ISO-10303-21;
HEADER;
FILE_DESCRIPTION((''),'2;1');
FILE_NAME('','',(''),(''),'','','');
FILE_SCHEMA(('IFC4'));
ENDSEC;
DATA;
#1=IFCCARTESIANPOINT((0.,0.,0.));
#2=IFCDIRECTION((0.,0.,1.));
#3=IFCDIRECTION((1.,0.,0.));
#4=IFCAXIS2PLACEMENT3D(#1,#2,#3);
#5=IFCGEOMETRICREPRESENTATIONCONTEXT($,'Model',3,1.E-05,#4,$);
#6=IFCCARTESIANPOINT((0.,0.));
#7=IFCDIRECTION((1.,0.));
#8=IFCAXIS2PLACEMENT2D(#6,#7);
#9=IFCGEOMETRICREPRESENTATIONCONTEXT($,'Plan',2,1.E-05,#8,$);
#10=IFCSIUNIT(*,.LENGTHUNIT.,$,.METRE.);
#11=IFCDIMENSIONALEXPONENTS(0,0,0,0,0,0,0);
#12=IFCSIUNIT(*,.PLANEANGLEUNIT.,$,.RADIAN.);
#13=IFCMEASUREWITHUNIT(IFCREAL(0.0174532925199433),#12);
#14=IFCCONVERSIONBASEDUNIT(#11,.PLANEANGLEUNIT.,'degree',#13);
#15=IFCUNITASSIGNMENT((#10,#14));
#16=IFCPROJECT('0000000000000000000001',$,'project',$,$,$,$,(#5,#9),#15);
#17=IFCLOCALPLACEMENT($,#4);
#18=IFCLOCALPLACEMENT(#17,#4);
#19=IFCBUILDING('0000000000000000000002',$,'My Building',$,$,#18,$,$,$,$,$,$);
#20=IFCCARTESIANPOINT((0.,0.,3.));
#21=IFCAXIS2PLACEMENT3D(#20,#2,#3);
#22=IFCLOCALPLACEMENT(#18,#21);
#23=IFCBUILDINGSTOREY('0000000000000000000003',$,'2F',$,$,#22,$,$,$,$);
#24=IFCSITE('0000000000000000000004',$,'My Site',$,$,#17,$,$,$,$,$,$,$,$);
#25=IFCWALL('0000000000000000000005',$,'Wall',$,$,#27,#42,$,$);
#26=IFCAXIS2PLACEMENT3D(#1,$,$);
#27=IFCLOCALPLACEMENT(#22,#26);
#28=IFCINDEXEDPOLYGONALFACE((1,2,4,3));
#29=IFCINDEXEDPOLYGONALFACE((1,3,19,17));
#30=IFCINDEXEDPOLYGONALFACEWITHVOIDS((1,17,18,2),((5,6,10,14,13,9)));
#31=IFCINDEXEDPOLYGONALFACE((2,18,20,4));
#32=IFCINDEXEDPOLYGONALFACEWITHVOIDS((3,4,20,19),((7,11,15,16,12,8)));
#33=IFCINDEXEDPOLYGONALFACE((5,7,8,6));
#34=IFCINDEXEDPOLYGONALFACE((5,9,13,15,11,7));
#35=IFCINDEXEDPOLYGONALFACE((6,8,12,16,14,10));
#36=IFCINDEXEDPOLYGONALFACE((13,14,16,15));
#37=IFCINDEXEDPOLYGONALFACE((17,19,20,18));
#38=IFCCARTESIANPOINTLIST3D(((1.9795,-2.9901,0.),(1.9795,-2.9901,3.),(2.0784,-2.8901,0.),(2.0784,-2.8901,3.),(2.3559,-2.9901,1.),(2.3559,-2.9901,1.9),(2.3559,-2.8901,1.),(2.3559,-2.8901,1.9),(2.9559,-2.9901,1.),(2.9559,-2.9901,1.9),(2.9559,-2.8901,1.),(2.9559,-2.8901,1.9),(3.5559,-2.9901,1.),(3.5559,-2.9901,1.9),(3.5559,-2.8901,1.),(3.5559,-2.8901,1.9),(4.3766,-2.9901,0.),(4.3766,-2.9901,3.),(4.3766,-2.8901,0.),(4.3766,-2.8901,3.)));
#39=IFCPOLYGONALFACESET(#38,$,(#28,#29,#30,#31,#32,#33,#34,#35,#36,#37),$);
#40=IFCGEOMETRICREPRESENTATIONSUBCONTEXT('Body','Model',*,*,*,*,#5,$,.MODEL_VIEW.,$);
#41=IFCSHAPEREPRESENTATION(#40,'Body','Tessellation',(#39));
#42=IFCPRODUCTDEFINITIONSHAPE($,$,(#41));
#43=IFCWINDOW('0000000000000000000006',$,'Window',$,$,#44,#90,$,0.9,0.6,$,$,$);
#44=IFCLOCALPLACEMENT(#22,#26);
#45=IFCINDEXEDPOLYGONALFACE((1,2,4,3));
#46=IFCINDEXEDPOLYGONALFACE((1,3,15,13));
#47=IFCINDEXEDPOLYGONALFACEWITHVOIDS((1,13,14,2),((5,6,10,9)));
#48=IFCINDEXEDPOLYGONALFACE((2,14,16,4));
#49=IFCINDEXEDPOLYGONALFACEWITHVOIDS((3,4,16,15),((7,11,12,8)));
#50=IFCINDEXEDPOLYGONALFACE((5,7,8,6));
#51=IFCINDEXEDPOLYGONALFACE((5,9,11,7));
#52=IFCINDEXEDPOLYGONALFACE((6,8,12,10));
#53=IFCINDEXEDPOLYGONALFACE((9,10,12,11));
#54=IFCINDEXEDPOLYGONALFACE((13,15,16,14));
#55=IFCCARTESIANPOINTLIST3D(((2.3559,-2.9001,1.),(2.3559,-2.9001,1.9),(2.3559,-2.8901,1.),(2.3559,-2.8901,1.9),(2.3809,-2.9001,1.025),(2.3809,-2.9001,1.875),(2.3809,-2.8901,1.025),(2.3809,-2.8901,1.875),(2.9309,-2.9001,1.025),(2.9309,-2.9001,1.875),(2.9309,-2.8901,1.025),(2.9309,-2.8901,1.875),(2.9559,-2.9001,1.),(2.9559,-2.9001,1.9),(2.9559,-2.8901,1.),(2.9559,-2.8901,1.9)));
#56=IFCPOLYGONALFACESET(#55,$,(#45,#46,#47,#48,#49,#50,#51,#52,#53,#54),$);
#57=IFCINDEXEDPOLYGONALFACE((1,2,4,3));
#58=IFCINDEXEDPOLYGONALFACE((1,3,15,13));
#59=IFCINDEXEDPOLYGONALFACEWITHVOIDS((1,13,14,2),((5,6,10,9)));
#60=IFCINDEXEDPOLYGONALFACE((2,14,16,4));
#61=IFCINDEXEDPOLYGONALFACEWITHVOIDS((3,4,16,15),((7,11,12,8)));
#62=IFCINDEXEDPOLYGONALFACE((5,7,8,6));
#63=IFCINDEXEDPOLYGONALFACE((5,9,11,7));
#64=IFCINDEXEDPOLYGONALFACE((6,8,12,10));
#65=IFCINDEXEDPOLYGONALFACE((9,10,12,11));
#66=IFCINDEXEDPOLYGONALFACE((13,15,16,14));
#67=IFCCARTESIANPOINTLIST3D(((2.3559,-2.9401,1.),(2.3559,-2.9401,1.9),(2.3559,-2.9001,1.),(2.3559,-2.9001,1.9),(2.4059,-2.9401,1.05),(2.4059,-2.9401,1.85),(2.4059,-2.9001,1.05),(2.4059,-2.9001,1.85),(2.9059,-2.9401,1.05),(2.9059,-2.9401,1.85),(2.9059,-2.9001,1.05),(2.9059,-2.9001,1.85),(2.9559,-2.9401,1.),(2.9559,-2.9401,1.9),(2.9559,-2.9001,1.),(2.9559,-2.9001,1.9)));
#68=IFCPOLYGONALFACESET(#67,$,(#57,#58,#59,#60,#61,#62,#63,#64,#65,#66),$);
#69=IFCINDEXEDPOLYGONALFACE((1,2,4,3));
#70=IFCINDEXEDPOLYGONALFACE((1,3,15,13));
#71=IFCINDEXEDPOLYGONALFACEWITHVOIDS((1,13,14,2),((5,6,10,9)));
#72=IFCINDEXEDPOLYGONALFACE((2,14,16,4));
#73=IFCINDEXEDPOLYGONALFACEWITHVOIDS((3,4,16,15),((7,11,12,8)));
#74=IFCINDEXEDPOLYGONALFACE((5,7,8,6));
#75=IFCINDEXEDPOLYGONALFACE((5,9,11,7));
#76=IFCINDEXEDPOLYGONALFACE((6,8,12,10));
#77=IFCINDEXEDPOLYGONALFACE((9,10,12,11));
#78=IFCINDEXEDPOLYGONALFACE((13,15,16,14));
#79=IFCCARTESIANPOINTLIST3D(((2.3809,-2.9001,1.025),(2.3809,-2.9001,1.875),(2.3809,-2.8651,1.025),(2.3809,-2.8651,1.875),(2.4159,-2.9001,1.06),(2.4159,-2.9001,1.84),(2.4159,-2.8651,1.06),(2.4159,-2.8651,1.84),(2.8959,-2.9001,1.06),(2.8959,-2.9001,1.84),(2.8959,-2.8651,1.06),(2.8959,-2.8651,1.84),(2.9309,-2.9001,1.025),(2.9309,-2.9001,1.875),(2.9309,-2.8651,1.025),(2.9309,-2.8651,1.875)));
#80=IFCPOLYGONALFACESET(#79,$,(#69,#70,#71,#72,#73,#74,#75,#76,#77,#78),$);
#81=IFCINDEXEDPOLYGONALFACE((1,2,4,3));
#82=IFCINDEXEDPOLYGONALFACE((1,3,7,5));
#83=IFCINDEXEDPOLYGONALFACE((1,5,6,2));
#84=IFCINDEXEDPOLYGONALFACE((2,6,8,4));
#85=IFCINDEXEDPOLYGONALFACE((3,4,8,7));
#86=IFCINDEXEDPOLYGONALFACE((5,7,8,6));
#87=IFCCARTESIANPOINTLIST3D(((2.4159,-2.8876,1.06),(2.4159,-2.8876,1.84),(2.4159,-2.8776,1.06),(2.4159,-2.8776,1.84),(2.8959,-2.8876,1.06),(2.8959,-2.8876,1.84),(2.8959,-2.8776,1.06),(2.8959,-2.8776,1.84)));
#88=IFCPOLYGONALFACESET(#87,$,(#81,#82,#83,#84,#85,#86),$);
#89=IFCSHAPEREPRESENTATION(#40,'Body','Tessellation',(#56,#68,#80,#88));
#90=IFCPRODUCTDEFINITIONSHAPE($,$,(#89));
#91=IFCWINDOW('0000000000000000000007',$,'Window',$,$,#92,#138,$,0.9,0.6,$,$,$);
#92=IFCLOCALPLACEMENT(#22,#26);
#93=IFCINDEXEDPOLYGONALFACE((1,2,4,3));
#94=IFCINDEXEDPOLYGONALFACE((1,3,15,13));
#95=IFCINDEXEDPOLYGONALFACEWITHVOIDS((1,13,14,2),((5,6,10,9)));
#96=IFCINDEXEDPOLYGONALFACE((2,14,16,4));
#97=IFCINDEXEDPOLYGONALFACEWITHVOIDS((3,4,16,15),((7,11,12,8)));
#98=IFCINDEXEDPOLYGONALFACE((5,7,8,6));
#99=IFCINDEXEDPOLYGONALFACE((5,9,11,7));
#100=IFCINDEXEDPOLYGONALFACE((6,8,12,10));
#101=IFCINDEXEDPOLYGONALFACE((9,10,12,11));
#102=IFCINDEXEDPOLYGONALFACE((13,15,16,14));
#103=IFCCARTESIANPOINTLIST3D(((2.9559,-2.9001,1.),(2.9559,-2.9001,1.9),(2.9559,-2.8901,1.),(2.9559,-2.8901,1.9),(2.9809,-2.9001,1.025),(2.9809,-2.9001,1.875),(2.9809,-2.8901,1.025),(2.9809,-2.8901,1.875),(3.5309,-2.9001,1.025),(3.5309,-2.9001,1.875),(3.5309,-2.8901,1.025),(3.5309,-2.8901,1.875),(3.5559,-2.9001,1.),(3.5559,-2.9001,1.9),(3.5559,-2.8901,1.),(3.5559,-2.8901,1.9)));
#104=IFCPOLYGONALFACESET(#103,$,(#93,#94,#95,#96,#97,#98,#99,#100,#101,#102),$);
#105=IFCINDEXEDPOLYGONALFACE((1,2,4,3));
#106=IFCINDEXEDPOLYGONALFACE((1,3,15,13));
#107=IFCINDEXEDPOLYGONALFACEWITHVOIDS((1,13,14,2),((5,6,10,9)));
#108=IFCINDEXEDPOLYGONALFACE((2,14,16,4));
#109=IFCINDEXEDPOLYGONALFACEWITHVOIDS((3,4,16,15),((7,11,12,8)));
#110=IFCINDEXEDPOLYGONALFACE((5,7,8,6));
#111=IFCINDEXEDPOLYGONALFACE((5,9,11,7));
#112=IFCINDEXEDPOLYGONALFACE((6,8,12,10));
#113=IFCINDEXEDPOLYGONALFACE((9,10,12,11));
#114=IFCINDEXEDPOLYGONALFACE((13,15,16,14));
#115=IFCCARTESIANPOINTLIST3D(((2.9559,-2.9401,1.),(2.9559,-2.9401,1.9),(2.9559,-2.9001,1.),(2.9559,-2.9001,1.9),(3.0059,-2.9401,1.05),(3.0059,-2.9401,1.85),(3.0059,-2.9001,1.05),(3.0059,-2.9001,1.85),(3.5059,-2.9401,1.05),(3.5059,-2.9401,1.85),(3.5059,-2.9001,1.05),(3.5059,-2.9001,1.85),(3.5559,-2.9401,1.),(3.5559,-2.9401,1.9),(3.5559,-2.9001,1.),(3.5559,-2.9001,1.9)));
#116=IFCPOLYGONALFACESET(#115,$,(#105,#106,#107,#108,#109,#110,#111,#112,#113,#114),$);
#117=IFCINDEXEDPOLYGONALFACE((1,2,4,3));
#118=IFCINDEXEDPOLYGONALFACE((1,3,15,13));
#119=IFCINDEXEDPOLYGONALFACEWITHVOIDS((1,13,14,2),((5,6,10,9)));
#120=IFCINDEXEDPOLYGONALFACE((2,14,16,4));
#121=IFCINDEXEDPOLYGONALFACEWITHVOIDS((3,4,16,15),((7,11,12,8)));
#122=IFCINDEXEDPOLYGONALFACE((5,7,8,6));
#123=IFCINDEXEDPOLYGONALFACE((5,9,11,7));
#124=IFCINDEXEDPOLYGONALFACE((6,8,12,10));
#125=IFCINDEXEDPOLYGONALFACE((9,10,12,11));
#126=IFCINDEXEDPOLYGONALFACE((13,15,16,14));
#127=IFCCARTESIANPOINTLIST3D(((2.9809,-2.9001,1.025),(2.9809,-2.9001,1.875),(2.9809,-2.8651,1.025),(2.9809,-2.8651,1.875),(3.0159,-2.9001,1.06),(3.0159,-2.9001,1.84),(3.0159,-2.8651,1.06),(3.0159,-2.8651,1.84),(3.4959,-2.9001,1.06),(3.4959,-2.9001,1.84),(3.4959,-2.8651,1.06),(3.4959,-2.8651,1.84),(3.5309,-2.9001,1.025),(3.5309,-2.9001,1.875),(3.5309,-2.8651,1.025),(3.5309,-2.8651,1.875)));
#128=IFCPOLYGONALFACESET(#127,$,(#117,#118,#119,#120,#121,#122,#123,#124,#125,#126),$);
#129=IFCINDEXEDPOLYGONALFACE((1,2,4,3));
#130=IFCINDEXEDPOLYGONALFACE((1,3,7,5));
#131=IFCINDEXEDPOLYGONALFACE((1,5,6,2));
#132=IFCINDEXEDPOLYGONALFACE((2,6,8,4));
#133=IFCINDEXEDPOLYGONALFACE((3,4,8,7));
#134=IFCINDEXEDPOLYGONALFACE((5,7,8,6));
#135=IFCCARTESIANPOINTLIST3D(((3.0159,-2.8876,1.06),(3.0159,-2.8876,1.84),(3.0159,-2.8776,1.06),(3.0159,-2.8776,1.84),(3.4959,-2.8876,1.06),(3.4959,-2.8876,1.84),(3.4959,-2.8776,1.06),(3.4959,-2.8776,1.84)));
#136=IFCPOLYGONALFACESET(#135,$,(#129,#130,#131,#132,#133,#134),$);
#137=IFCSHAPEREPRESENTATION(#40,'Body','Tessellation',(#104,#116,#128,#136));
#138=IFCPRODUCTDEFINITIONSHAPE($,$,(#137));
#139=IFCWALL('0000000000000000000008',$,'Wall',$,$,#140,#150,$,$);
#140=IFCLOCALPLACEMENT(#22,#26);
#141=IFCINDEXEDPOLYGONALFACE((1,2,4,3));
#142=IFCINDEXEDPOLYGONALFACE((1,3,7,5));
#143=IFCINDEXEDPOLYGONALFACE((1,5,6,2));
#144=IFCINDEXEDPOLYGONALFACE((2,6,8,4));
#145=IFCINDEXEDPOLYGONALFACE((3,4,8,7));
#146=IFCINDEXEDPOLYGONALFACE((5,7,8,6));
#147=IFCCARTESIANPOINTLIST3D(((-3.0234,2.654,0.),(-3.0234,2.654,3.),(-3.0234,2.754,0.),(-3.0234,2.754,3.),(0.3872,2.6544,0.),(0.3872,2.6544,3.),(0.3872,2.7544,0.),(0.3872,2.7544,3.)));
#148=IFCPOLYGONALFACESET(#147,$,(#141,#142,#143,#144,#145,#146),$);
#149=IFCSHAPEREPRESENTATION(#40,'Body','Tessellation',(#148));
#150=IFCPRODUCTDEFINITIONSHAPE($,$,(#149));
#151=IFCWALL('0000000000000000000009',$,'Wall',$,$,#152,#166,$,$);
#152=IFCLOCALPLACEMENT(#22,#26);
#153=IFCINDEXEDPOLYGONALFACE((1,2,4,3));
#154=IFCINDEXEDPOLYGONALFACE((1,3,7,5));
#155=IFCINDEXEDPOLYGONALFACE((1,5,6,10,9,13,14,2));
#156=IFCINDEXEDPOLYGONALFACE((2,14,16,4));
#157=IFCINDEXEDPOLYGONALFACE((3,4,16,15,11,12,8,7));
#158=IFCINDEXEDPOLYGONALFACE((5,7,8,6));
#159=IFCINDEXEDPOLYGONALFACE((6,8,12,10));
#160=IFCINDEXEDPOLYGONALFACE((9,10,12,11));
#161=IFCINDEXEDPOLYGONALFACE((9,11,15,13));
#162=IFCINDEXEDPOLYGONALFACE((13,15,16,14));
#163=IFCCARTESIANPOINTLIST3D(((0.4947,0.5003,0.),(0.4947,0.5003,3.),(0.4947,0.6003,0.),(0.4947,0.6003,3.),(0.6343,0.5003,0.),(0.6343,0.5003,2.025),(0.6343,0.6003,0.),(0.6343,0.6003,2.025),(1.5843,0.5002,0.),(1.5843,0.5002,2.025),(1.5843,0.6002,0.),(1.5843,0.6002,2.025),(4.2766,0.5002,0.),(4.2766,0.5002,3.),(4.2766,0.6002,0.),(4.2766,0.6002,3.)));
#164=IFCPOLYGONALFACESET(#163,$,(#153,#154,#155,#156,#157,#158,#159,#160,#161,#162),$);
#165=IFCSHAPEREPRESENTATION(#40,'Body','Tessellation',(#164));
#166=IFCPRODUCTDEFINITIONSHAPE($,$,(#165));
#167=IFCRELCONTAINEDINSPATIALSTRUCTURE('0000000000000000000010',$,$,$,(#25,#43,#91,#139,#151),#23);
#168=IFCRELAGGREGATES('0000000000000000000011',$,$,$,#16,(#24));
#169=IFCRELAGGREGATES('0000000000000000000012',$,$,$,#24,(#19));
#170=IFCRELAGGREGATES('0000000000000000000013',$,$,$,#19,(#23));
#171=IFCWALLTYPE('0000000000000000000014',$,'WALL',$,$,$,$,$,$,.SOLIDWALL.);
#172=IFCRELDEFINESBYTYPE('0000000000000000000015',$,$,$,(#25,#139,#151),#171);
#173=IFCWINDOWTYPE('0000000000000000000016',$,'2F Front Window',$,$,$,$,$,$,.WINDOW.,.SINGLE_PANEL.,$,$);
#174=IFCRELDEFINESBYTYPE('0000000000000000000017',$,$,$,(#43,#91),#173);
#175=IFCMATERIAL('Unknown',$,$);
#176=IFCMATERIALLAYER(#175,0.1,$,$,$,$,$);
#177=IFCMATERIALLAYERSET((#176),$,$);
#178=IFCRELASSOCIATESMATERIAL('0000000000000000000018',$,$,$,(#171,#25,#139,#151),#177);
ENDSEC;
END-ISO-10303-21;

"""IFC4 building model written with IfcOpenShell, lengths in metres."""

from ifc_helpers import new_model, entity, si_unit, converted_unit, frame, origin_with_axes, origin_2d_with_axis, place, context, subcontext, project, spatial, line, indexed_curve, outline, extrude, shape, source, transform, mapped, material, layer, layer_set, layer_usage, type_object, type_shapes, element, fill, save


model = new_model("IFC4")

# Units and contexts
model_context = context("Model", 3, precision=1e-05, world=origin_with_axes())
plan_context = context("Plan", 2, precision=1e-05, world=origin_2d_with_axis())
body_context_1 = subcontext(model_context, "Body", "Model", "MODEL_VIEW")
body_context_2 = subcontext(plan_context, "Body", "Plan", "PLAN_VIEW")
ifc_project = project(units=[si_unit("LENGTHUNIT", "METRE"), converted_unit("PLANEANGLEUNIT", "degree", entity("IfcReal", 0.0174532925199433), si_unit("PLANEANGLEUNIT", "RADIAN"), dimensions=[0, 0, 0, 0, 0, 0, 0])], contexts=[model_context, plan_context])

# Site, building, storey
site_placement = place(None, origin_with_axes())
site = spatial("IfcSite", under=ifc_project, at=site_placement, Name="My Site")
building_placement = place(site_placement, origin_with_axes())
building = spatial("IfcBuilding", under=site, at=building_placement, Name="My Building")
storey_placement = place(building_placement, frame((0.0, 0.0, 3.0), z_axis=(0.0, 0.0, 1.0), x_axis=(1.0, 0.0, 0.0)))
storey = spatial("IfcBuildingStorey", under=building, at=storey_placement, Name="2F")

# Shared definitions
ifc_material = material(Name="Unknown")

# Shared definitions
ifc_layer = layer(ifc_material, 0.1)
ifc_layer_set = layer_set([ifc_layer])
wall_type = type_object("IfcWallType", Name="WALL", PredefinedType="SOLIDWALL", material=ifc_layer_set)

# Wall, openings, windows
ifc_layer_usage_1 = layer_usage(ifc_layer_set, "AXIS2", "POSITIVE", 0.0)
wall_1_placement = place(storey_placement, frame((1.9795, -2.9901, 0.0), z_axis=(0.0, 0.0, 1.0), x_axis=(1.0, 0.0, 0.0)))
wall_1 = element("IfcWall", 1, at=wall_1_placement, inside=storey, type_object=wall_type, material=ifc_layer_usage_1, Name="Wall", context=body_context_1, shape_type="SweptSolid", body=[
    extrude(outline(indexed_curve([(0.0, 0.0), (0.0989, 0.1), (2.3971, 0.1), (2.3971, 0.0)], segments=[line(1, 2, 3, 4, 1)])), origin_with_axes(), (0.0, 0.0, 1.0), 3.0),
])
shared_shape_1 = source(origin_with_axes(), body_context_1, "Body", "SweptSolid", [
    extrude(outline(indexed_curve([(0.0, 0.0), (0.6, 0.0), (0.6, 0.9), (0.0, 0.9)], segments=[line(1, 2, 3, 4, 1)])), frame((0.0, -0.6, 0.0), z_axis=(0.0, -1.0, 0.0), x_axis=(1.0, 0.0, 0.0)), (0.0, 0.0, -1.0), 1.2),
])
opening_1_placement = place(wall_1_placement, frame((0.3764, 0.0, 1.0), z_axis=(0.0, 0.0, 1.0), x_axis=(1.0, 0.0, 0.0)))
opening_1 = element("IfcOpeningElement", 2, at=opening_1_placement, cuts=wall_1, PredefinedType="OPENING", context=body_context_1, shape_type="MappedRepresentation", body=[
    mapped(shared_shape_1, transform((0.0, 0.0, 0.0), x_axis=(1.0, 0.0, 0.0), y_axis=(0.0, 1.0, 0.0), z_axis=(0.0, 0.0, 1.0), scale=1.0)),
])
opening_2_placement = place(wall_1_placement, frame((0.9764, 0.0, 1.0), z_axis=(0.0, 0.0, 1.0), x_axis=(1.0, 0.0, 0.0)))
opening_2 = element("IfcOpeningElement", 3, at=opening_2_placement, cuts=wall_1, PredefinedType="OPENING", context=body_context_1, shape_type="MappedRepresentation", body=[
    mapped(shared_shape_1, transform((0.0, 0.0, 0.0), x_axis=(1.0, 0.0, 0.0), y_axis=(0.0, 1.0, 0.0), z_axis=(0.0, 0.0, 1.0), scale=1.0)),
])
window_type = type_object("IfcWindowType", Name="2F Front Window", PartitioningType="SINGLE_PANEL", PredefinedType="WINDOW")
shared_shape_2 = source(origin_with_axes(), body_context_1, "Body", "SweptSolid", [
    extrude(outline(indexed_curve([(0.0, 0.0), (0.6, 0.0), (0.6, 0.9), (0.0, 0.9)], segments=[line(1, 2, 3, 4, 1)]), holes=[indexed_curve([(0.025, 0.025), (0.575, 0.025), (0.575, 0.875), (0.025, 0.875)], segments=[line(1, 2, 3, 4, 1)])]), frame((0.0, 0.09, 0.0), z_axis=(0.0, -1.0, 0.0), x_axis=(1.0, 0.0, 0.0)), (0.0, 0.0, -1.0), 0.01),
    extrude(outline(indexed_curve([(0.0, 0.0), (0.6, 0.0), (0.6, 0.9), (0.0, 0.9)], segments=[line(1, 2, 3, 4, 1)]), holes=[indexed_curve([(0.05, 0.05), (0.55, 0.05), (0.55, 0.85), (0.05, 0.85)], segments=[line(1, 2, 3, 4, 1)])]), frame((0.0, 0.05, 0.0), z_axis=(0.0, -1.0, 0.0), x_axis=(1.0, 0.0, 0.0)), (0.0, 0.0, -1.0), 0.04),
    extrude(outline(indexed_curve([(0.0, 0.0), (0.55, 0.0), (0.55, 0.85), (0.0, 0.85)], segments=[line(1, 2, 3, 4, 1)]), holes=[indexed_curve([(0.035, 0.035), (0.515, 0.035), (0.515, 0.815), (0.035, 0.815)], segments=[line(1, 2, 3, 4, 1)])]), frame((0.025, 0.09, 0.025), z_axis=(0.0, -1.0, 0.0), x_axis=(1.0, 0.0, 0.0)), (0.0, 0.0, -1.0), 0.035),
    extrude(outline(indexed_curve([(0.035, 0.035), (0.515, 0.035), (0.515, 0.815), (0.035, 0.815)], segments=[line(1, 2, 3, 4, 1)])), frame((0.025, 0.1025, 0.025), z_axis=(0.0, -1.0, 0.0), x_axis=(1.0, 0.0, 0.0)), (0.0, 0.0, -1.0), 0.01),
])
shared_shape_3 = source(origin_with_axes(), body_context_2, "Body", "Curve2D", [
    entity("IfcIndexedPolyCurve", entity("IfcCartesianPointList2D", [[0.05, 0.05], [0.55, 0.05]])),
    entity("IfcIndexedPolyCurve", entity("IfcCartesianPointList2D", [[0.0, 0.1], [0.025, 0.1], [0.025, 0.09], [0.05, 0.09], [0.05, 0.05], [0.0, 0.05]]), [entity("IfcLineIndex", [1, 2, 3, 4, 5, 6, 1])]),
    entity("IfcIndexedPolyCurve", entity("IfcCartesianPointList2D", [[0.6, 0.1], [0.575, 0.1], [0.575, 0.09], [0.55, 0.09], [0.55, 0.05], [0.6, 0.05]]), [entity("IfcLineIndex", [1, 2, 3, 4, 5, 6, 1])]),
    entity("IfcIndexedPolyCurve", entity("IfcCartesianPointList2D", [[0.025, 0.09], [0.06, 0.09], [0.06, 0.125], [0.025, 0.125]]), [entity("IfcLineIndex", [1, 2, 3, 4, 1])]),
    entity("IfcIndexedPolyCurve", entity("IfcCartesianPointList2D", [[0.575, 0.09], [0.54, 0.09], [0.54, 0.125], [0.575, 0.125]]), [entity("IfcLineIndex", [1, 2, 3, 4, 1])]),
    entity("IfcIndexedPolyCurve", entity("IfcCartesianPointList2D", [[0.06, 0.09], [0.54, 0.09]])),
    entity("IfcIndexedPolyCurve", entity("IfcCartesianPointList2D", [[0.06, 0.125], [0.54, 0.125]])),
    entity("IfcIndexedPolyCurve", entity("IfcCartesianPointList2D", [[0.06, 0.1075], [0.54, 0.1075]])),
])
type_shapes(window_type, [shared_shape_2, shared_shape_3])
window_1_placement = place(opening_1_placement, frame((0.0, 0.0, 0.0), z_axis=(0.0, 0.0, 1.0), x_axis=(1.0, 0.0, 0.0)))
window_1 = element("IfcWindow", 4, at=window_1_placement, inside=storey, type_object=window_type, Name="Window", OverallHeight=0.9, OverallWidth=0.6, shapes=[
    shape(body_context_1, "Body", "MappedRepresentation", [mapped(shared_shape_2, transform((0.0, 0.0, 0.0), x_axis=(1.0, 0.0, 0.0), y_axis=(0.0, 1.0, 0.0), z_axis=(0.0, 0.0, 1.0), scale=1.0))]),
    shape(body_context_2, "Body", "MappedRepresentation", [mapped(shared_shape_3, transform((0.0, 0.0, 0.0), x_axis=(1.0, 0.0, 0.0), y_axis=(0.0, 1.0, 0.0), z_axis=(0.0, 0.0, 1.0), scale=1.0))]),
])
fill(opening_1, window_1)
window_2_placement = place(opening_2_placement, frame((0.0, 0.0, 0.0), z_axis=(0.0, 0.0, 1.0), x_axis=(1.0, 0.0, 0.0)))
window_2 = element("IfcWindow", 5, at=window_2_placement, inside=storey, type_object=window_type, Name="Window", OverallHeight=0.9, OverallWidth=0.6, shapes=[
    shape(body_context_1, "Body", "MappedRepresentation", [mapped(shared_shape_2, transform((0.0, 0.0, 0.0), x_axis=(1.0, 0.0, 0.0), y_axis=(0.0, 1.0, 0.0), z_axis=(0.0, 0.0, 1.0), scale=1.0))]),
    shape(body_context_2, "Body", "MappedRepresentation", [mapped(shared_shape_3, transform((0.0, 0.0, 0.0), x_axis=(1.0, 0.0, 0.0), y_axis=(0.0, 1.0, 0.0), z_axis=(0.0, 0.0, 1.0), scale=1.0))]),
])
fill(opening_2, window_2)

# Wall
ifc_layer_usage_2 = layer_usage(ifc_layer_set, "AXIS2", "POSITIVE", 0.0)
wall_2_placement = place(storey_placement, frame((-3.0234, 2.654, 0.0), z_axis=(0.0, 0.0, 1.0), x_axis=(1.0, 0.000117, 0.0)))
element("IfcWall", 6, at=wall_2_placement, inside=storey, type_object=wall_type, material=ifc_layer_usage_2, Name="Wall", context=body_context_1, shape_type="SweptSolid", body=[
    extrude(outline(indexed_curve([(0.0, 0.0), (0.0, 0.1), (3.4106, 0.1), (3.4106, 0.0)], segments=[line(1, 2, 3, 4, 1)])), origin_with_axes(), (0.0, 0.0, 1.0), 3.0),
])

# Wall, opening
ifc_layer_usage_3 = layer_usage(ifc_layer_set, "AXIS2", "POSITIVE", 0.0)
wall_3_placement = place(storey_placement, frame((4.2766, 0.6002, 0.0), z_axis=(0.0, 0.0, 1.0), x_axis=(-1.0, 0.000024, 0.0)))
wall_3 = element("IfcWall", 7, at=wall_3_placement, inside=storey, type_object=wall_type, material=ifc_layer_usage_3, Name="Wall", context=body_context_1, shape_type="SweptSolid", body=[
    extrude(outline(indexed_curve([(0.0, 0.0), (0.0, 0.1), (3.782, 0.1), (3.782, 0.0)], segments=[line(1, 2, 3, 4, 1)])), origin_with_axes(), (0.0, 0.0, 1.0), 3.0),
])
shared_shape_4 = source(origin_with_axes(), body_context_1, "Body", "SweptSolid", [
    extrude(outline(indexed_curve([(0.0, 0.0), (0.95, 0.0), (0.95, 2.025), (0.0, 2.025)], segments=[line(1, 2, 3, 4, 1)])), frame((-0.025, -0.6, 0.0), z_axis=(0.0, -1.0, 0.0), x_axis=(1.0, 0.0, 0.0)), (0.0, 0.0, -1.0), 1.2),
])
opening_3_placement = place(wall_3_placement, frame((2.7173, 0.0, 0.0), z_axis=(0.0, 0.0, 1.0), x_axis=(1.0, 0.0, 0.0)))
element("IfcOpeningElement", 8, at=opening_3_placement, cuts=wall_3, PredefinedType="OPENING", context=body_context_1, shape_type="MappedRepresentation", body=[
    mapped(shared_shape_4, transform((0.0, 0.0, 0.0), x_axis=(1.0, 0.0, 0.0), y_axis=(0.0, 1.0, 0.0), z_axis=(0.0, 0.0, 1.0), scale=1.0)),
])

save(model, "model.ifc")
